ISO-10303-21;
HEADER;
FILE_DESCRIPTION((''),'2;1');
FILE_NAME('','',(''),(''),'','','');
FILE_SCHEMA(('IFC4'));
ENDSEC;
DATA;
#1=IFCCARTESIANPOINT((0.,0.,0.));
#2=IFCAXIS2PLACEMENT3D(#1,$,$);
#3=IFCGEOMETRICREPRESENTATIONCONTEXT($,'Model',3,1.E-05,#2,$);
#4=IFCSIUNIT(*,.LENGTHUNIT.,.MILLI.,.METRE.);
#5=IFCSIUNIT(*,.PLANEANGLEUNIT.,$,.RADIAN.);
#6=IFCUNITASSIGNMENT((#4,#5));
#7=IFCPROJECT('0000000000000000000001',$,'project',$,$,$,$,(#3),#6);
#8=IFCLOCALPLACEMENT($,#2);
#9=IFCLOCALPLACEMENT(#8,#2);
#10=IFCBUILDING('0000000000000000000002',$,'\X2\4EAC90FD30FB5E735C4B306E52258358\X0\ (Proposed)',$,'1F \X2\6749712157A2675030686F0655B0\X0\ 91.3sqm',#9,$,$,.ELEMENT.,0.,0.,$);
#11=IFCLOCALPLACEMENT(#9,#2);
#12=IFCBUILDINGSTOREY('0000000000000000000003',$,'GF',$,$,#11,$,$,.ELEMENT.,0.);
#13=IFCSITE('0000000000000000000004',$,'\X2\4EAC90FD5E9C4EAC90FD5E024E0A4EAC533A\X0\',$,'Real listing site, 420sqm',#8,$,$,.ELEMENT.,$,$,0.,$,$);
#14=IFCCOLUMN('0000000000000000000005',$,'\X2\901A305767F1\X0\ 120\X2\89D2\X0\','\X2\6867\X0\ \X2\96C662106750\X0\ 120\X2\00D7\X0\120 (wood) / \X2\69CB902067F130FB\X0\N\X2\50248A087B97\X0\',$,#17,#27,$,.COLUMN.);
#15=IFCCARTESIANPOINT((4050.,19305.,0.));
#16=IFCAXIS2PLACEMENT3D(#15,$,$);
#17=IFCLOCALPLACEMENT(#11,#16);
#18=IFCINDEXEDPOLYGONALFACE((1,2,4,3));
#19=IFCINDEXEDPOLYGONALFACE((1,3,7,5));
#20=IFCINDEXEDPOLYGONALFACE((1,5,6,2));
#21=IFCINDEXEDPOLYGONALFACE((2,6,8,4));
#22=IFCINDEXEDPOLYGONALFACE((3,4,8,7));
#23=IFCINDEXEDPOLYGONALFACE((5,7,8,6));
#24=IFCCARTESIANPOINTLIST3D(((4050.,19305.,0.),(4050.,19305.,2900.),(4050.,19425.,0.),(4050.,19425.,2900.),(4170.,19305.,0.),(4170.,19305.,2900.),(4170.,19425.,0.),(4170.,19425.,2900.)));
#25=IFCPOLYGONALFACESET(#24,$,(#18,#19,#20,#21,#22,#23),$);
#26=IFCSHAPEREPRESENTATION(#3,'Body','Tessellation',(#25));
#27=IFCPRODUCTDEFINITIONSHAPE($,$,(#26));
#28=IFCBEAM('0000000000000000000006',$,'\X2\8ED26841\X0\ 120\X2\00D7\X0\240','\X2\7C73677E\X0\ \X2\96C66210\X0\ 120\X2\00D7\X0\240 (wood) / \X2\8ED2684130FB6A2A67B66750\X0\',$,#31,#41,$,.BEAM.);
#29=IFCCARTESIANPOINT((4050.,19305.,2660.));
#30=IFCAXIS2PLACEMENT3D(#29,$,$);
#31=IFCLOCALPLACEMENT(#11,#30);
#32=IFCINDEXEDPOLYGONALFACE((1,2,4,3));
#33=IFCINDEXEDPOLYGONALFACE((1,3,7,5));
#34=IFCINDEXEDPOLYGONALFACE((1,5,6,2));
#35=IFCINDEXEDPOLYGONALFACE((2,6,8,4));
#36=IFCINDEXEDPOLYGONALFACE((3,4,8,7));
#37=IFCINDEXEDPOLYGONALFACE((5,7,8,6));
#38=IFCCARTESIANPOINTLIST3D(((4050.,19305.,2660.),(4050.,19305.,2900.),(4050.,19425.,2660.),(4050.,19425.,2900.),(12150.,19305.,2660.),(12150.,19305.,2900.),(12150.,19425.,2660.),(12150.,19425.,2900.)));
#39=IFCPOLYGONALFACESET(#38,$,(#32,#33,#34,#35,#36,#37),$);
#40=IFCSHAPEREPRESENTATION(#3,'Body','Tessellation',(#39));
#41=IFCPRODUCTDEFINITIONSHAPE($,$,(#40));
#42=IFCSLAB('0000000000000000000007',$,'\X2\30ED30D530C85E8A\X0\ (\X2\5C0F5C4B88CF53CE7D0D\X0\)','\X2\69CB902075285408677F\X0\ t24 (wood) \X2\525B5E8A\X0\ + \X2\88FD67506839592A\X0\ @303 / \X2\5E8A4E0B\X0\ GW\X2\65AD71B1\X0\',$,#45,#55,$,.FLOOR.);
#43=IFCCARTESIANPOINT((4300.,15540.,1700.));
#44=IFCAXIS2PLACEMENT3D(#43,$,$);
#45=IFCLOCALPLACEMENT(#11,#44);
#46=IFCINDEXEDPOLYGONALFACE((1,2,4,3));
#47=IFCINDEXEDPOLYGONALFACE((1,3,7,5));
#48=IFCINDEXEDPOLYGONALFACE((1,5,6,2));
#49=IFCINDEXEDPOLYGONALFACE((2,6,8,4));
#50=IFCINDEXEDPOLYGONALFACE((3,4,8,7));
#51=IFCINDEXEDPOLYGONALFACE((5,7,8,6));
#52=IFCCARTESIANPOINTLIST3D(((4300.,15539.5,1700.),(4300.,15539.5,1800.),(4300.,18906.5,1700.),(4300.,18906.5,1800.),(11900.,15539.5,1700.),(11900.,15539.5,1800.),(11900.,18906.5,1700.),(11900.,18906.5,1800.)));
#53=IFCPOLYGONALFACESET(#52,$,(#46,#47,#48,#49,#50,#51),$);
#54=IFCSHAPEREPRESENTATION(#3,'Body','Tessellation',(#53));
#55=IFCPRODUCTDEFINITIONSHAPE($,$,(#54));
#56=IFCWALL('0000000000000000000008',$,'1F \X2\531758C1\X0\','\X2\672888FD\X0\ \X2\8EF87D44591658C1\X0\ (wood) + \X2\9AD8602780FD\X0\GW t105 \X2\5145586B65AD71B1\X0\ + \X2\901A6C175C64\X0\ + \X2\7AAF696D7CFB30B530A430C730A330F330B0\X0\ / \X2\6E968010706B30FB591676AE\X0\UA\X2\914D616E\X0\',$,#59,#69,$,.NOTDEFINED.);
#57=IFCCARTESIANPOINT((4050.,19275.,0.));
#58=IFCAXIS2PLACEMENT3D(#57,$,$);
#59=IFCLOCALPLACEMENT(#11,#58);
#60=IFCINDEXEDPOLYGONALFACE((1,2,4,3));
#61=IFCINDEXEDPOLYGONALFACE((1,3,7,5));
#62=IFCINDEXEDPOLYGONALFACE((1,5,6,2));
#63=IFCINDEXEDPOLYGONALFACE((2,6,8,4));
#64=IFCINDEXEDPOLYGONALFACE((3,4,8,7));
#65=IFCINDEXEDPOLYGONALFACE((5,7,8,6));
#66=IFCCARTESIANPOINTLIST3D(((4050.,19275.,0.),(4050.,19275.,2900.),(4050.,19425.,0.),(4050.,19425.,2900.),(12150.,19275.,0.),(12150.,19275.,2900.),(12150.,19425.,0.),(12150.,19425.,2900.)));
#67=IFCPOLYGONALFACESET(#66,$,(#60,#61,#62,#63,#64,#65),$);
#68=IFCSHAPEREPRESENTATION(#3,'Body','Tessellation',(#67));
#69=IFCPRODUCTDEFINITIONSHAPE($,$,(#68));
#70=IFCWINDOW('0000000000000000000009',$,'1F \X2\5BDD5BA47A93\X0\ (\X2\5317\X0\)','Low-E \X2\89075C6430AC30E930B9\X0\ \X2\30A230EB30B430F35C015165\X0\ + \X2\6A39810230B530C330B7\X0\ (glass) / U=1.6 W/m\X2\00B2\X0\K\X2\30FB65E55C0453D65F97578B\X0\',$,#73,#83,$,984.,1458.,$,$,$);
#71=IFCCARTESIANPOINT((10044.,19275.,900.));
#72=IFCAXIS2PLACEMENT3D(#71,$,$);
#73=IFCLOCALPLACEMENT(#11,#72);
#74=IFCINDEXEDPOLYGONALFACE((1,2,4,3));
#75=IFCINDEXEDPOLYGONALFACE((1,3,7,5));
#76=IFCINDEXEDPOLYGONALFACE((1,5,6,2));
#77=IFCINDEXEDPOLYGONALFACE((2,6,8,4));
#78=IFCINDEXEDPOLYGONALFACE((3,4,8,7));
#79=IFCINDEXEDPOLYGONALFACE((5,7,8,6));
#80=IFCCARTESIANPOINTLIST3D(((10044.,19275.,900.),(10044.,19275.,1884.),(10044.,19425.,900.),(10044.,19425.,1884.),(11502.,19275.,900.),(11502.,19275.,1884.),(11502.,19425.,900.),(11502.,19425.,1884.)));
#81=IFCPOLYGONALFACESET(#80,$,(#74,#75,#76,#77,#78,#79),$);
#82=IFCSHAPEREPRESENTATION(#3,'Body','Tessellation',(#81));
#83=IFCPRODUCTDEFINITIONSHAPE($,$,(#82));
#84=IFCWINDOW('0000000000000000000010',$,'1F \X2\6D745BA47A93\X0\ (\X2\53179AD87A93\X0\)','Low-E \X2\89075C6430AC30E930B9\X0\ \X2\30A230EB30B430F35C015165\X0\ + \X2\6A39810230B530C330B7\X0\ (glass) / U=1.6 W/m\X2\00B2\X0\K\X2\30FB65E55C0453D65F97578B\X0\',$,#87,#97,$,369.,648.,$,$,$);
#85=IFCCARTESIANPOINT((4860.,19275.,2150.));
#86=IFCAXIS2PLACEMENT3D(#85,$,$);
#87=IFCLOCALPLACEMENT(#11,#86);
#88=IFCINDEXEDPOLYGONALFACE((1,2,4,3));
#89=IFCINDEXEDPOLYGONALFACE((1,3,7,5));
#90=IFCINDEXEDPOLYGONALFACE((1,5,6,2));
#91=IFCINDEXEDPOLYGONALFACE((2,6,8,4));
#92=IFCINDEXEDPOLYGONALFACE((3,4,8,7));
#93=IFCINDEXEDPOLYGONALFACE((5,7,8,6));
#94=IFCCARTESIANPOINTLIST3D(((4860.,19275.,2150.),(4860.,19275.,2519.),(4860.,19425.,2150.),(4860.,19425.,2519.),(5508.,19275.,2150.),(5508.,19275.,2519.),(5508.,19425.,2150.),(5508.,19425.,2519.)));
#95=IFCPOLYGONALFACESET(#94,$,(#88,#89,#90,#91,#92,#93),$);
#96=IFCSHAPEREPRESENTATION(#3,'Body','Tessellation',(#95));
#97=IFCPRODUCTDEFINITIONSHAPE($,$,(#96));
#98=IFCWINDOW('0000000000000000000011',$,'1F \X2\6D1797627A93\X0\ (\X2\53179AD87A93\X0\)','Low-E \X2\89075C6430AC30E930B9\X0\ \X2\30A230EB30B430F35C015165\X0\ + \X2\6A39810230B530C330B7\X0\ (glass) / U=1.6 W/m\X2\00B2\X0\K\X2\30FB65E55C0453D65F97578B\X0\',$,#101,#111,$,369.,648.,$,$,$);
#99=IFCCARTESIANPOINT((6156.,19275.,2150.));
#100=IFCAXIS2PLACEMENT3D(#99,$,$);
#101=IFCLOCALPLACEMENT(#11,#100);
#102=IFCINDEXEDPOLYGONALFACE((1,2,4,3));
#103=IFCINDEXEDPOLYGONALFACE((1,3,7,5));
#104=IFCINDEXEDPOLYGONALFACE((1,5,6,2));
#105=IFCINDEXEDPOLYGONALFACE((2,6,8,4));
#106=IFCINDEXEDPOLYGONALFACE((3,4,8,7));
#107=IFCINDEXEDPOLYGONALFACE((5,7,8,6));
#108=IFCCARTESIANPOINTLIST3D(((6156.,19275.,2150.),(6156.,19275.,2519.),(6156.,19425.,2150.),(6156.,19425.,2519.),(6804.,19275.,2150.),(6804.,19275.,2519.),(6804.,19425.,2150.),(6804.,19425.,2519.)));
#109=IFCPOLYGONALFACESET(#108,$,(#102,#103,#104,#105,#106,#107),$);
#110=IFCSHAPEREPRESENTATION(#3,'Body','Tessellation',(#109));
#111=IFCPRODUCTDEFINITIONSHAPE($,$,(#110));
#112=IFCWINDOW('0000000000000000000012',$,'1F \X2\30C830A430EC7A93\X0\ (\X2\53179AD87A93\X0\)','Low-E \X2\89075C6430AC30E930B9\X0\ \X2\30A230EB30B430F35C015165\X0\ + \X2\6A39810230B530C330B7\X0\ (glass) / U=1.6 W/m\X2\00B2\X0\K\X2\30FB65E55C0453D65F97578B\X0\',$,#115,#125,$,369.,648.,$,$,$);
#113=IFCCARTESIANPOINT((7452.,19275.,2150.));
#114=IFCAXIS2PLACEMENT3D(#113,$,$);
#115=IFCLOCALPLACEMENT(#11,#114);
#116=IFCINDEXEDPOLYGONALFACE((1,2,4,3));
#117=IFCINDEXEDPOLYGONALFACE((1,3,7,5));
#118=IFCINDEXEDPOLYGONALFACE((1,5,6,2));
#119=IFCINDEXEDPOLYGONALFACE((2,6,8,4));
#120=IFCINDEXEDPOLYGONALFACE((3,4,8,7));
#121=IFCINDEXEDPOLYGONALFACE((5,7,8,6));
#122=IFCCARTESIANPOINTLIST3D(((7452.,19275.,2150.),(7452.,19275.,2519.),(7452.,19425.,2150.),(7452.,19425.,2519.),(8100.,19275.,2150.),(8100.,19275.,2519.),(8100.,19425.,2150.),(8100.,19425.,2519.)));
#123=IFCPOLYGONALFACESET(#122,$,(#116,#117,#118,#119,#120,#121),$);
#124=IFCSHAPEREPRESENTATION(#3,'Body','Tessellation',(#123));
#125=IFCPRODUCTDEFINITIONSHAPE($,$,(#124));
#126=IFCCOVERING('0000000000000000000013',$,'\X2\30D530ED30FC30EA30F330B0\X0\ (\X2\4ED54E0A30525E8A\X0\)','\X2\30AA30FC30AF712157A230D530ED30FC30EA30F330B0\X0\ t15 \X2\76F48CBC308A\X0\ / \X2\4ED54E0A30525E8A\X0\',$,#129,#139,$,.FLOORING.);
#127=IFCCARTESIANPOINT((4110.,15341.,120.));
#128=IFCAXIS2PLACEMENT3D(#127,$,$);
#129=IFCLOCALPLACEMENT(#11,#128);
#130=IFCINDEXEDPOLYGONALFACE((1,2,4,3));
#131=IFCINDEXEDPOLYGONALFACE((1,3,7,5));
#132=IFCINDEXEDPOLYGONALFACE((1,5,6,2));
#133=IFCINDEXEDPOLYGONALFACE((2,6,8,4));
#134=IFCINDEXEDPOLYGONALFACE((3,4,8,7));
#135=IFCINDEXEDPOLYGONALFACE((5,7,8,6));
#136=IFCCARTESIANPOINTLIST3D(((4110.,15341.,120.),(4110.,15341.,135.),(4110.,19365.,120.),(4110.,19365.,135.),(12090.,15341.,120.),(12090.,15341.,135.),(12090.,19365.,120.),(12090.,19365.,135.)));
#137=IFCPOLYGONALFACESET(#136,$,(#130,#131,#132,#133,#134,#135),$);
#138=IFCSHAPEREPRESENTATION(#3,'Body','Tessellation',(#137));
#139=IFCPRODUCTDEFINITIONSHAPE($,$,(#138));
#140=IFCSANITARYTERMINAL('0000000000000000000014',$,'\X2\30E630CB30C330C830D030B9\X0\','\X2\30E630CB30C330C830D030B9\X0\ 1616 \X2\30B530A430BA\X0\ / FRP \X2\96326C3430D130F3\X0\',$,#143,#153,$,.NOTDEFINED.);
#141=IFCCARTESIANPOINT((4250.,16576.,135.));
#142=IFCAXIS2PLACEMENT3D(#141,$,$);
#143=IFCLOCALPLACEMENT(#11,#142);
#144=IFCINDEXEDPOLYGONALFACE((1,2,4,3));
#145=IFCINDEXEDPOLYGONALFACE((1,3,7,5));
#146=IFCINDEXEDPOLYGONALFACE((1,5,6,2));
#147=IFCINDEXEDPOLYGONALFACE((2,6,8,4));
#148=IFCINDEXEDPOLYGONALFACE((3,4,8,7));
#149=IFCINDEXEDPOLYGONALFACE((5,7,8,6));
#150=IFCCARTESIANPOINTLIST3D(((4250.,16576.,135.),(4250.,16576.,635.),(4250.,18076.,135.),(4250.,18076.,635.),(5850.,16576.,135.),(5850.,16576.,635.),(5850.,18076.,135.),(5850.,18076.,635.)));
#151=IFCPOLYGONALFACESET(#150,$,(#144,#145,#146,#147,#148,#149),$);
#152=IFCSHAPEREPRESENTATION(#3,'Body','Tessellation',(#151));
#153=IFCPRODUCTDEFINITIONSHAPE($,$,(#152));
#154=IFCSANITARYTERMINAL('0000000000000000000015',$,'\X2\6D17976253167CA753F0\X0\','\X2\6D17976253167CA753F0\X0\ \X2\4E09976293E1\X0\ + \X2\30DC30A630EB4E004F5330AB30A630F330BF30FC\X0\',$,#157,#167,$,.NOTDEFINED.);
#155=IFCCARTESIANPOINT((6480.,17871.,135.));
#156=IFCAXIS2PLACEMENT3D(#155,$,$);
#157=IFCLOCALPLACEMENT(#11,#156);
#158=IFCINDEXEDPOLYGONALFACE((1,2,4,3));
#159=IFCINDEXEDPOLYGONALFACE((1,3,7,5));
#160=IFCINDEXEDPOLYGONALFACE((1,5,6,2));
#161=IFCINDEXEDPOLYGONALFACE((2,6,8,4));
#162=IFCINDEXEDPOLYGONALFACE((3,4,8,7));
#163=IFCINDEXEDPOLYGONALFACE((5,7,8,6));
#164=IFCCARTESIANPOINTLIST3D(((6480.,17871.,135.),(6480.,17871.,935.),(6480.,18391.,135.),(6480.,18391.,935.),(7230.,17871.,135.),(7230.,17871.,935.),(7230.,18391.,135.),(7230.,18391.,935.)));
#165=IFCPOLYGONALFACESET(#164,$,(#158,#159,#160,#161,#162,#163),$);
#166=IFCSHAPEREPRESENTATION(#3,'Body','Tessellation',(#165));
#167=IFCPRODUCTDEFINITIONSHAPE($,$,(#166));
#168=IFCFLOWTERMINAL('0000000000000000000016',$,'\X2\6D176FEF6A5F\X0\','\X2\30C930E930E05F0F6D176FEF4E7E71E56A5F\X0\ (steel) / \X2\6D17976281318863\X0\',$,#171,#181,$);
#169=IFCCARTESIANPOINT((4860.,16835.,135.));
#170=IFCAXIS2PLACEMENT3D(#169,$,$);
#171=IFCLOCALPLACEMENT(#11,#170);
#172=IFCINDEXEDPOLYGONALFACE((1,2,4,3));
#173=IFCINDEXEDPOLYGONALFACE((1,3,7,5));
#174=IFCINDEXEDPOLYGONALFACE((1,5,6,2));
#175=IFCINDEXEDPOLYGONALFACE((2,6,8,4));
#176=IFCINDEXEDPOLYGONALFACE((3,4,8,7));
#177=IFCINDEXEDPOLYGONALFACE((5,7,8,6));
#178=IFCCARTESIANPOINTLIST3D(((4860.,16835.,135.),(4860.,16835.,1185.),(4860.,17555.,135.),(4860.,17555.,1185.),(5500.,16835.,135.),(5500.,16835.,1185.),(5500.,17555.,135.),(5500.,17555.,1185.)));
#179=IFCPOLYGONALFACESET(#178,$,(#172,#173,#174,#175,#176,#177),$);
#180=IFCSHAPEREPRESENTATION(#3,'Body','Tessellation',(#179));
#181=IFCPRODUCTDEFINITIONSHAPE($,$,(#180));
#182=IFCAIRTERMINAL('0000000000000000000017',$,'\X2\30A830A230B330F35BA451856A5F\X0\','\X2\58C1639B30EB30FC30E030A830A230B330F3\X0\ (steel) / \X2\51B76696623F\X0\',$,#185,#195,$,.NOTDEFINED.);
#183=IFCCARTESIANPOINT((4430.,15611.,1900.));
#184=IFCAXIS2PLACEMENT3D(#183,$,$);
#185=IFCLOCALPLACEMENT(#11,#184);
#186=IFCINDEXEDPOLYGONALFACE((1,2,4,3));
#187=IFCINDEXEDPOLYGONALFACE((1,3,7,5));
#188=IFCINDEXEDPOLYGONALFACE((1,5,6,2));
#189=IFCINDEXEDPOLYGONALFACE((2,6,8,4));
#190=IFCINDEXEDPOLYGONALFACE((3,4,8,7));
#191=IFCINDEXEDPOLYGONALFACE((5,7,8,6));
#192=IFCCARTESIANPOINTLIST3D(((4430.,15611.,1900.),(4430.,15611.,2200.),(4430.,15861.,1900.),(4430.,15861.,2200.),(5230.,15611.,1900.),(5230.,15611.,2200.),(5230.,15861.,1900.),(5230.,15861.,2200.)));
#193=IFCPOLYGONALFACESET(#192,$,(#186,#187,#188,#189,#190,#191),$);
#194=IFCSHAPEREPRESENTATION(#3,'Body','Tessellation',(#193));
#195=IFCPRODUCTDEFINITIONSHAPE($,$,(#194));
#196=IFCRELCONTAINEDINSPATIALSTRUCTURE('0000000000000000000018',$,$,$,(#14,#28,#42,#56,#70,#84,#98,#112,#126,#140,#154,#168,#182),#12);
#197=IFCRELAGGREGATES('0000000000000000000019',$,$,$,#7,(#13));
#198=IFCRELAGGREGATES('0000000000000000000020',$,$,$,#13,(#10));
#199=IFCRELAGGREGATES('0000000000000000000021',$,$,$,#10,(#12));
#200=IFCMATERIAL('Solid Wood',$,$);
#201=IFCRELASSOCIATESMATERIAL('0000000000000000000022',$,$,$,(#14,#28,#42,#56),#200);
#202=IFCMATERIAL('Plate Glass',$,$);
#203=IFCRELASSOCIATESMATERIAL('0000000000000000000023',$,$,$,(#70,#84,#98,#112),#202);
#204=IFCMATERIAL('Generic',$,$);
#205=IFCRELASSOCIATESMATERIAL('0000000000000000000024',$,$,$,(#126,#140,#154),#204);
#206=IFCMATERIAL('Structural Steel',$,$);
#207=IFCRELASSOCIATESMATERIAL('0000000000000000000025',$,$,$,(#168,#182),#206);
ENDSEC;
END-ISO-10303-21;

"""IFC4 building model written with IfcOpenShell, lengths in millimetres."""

from ifc_helpers import new_model, si_unit, frame, frame_2d, origin, place, context, project, spatial, rectangle, extrude, material, element, fill, save


model = new_model("IFC4")

# Units and contexts
model_context = context("Model", 3, precision=1e-05, world=origin())
ifc_project = project(units=[si_unit("LENGTHUNIT", "METRE", prefix="MILLI"), si_unit("PLANEANGLEUNIT", "RADIAN")], contexts=[model_context])

# Site, building, storey
site_placement = place(None, origin())
site = spatial("IfcSite", under=ifc_project, at=site_placement, Name="京都府京都市上京区", ObjectType="Real listing site, 420sqm", CompositionType="ELEMENT", RefElevation=0.0)
building_placement = place(site_placement, origin())
building = spatial("IfcBuilding", under=site, at=building_placement, Name="京都・平屋の別荘 (Proposed)", ObjectType="1F 杉無垢材と漆喰 91.3sqm", CompositionType="ELEMENT", ElevationOfRefHeight=0.0, ElevationOfTerrain=0.0)
storey_placement = place(building_placement, origin())
storey = spatial("IfcBuildingStorey", under=building, at=storey_placement, Name="GF", CompositionType="ELEMENT", Elevation=0.0)

# Column
ifc_material_1 = material(Name="Solid Wood")
column_1_placement = place(storey_placement, frame((4050.0, 19305.0, 0.0)))
element("IfcColumn", 1, at=column_1_placement, inside=storey, material=ifc_material_1, Name="通し柱 120角", Description="桧 集成材 120×120 (wood) / 構造柱・N値計算", PredefinedType="COLUMN", context=model_context, shape_type="SweptSolid", body=[
    extrude(rectangle(XDim=120.0, YDim=120.0, at=frame_2d((60.0, 60.0))), frame((4050.0, 19305.0, 0.0)), (0.0, 0.0, 1.0), 2900.0),
])

# Beam
beam_1_placement = place(storey_placement, frame((4050.0, 19305.0, 2660.0)))
element("IfcBeam", 2, at=beam_1_placement, inside=storey, material=ifc_material_1, Name="軒桁 120×240", Description="米松 集成 120×240 (wood) / 軒桁・横架材", PredefinedType="BEAM", context=model_context, shape_type="SweptSolid", body=[
    extrude(rectangle(XDim=8100.0, YDim=120.0, at=frame_2d((4050.0, 60.0))), frame((4050.0, 19305.0, 2660.0)), (0.0, 0.0, 1.0), 240.0),
])

# Slab
slab_placement = place(storey_placement, frame((4300.0, 15540.0, 1700.0)))
element("IfcSlab", 3, at=slab_placement, inside=storey, material=ifc_material_1, Name="ロフト床 (小屋裏収納)", Description="構造用合板 t24 (wood) 剛床 + 製材根太 @303 / 床下 GW断熱", PredefinedType="FLOOR", context=model_context, shape_type="SweptSolid", body=[
    extrude(rectangle(XDim=7600.0, YDim=3367.0, at=frame_2d((3800.0, 1683.0))), frame((4300.0, 15540.0, 1700.0)), (0.0, 0.0, 1.0), 100.0),
])

# Wall, openings, windows
wall_1_placement = place(storey_placement, frame((4050.0, 19275.0, 0.0)))
wall_1 = element("IfcWall", 4, at=wall_1_placement, inside=storey, material=ifc_material_1, Name="1F 北壁", Description="木製 軸組外壁 (wood) + 高性能GW t105 充填断熱 + 通気層 + 窯業系サイディング / 準耐火・外皮UA配慮", PredefinedType="NOTDEFINED", context=model_context, shape_type="SweptSolid", body=[
    extrude(rectangle(XDim=8100.0, YDim=150.0, at=frame_2d((4050.0, 75.0))), frame((4050.0, 19275.0, 0.0)), (0.0, 0.0, 1.0), 2900.0),
])
opening_1_placement = place(storey_placement, frame((10044.0, 19275.0, 900.0)))
opening_1 = element("IfcOpeningElement", 5, at=opening_1_placement, cuts=wall_1, PredefinedType="NOTDEFINED", context=model_context, shape_type="SweptSolid", body=[
    extrude(rectangle(XDim=1458.0, YDim=150.0, at=frame_2d((729.0, 75.0))), frame((10044.0, 19275.0, 900.0)), (0.0, 0.0, 1.0), 984.0),
])
opening_2_placement = place(storey_placement, frame((4860.0, 19275.0, 2150.0)))
opening_2 = element("IfcOpeningElement", 6, at=opening_2_placement, cuts=wall_1, PredefinedType="NOTDEFINED", context=model_context, shape_type="SweptSolid", body=[
    extrude(rectangle(XDim=648.0, YDim=150.0, at=frame_2d((324.0, 75.0))), frame((4860.0, 19275.0, 2150.0)), (0.0, 0.0, 1.0), 369.0),
])
opening_3_placement = place(storey_placement, frame((6156.0, 19275.0, 2150.0)))
opening_3 = element("IfcOpeningElement", 7, at=opening_3_placement, cuts=wall_1, PredefinedType="NOTDEFINED", context=model_context, shape_type="SweptSolid", body=[
    extrude(rectangle(XDim=648.0, YDim=150.0, at=frame_2d((324.0, 75.0))), frame((6156.0, 19275.0, 2150.0)), (0.0, 0.0, 1.0), 369.0),
])
opening_4_placement = place(storey_placement, frame((7452.0, 19275.0, 2150.0)))
opening_4 = element("IfcOpeningElement", 8, at=opening_4_placement, cuts=wall_1, PredefinedType="NOTDEFINED", context=model_context, shape_type="SweptSolid", body=[
    extrude(rectangle(XDim=648.0, YDim=150.0, at=frame_2d((324.0, 75.0))), frame((7452.0, 19275.0, 2150.0)), (0.0, 0.0, 1.0), 369.0),
])
ifc_material_2 = material(Name="Plate Glass")
window_1_placement = place(storey_placement, frame((10044.0, 19275.0, 900.0)))
window_1 = element("IfcWindow", 9, at=window_1_placement, inside=storey, material=ifc_material_2, Name="1F 寝室窓 (北)", Description="Low-E 複層ガラス アルゴン封入 + 樹脂サッシ (glass) / U=1.6 W/m²K・日射取得型", OverallHeight=984.0, OverallWidth=1458.0, context=model_context, shape_type="SweptSolid", body=[
    extrude(rectangle(XDim=1458.0, YDim=150.0, at=frame_2d((729.0, 75.0))), frame((10044.0, 19275.0, 900.0)), (0.0, 0.0, 1.0), 984.0),
])
fill(opening_1, window_1)
window_2_placement = place(storey_placement, frame((4860.0, 19275.0, 2150.0)))
window_2 = element("IfcWindow", 10, at=window_2_placement, inside=storey, material=ifc_material_2, Name="1F 浴室窓 (北高窓)", Description="Low-E 複層ガラス アルゴン封入 + 樹脂サッシ (glass) / U=1.6 W/m²K・日射取得型", OverallHeight=369.0, OverallWidth=648.0, context=model_context, shape_type="SweptSolid", body=[
    extrude(rectangle(XDim=648.0, YDim=150.0, at=frame_2d((324.0, 75.0))), frame((4860.0, 19275.0, 2150.0)), (0.0, 0.0, 1.0), 369.0),
])
fill(opening_2, window_2)
window_3_placement = place(storey_placement, frame((6156.0, 19275.0, 2150.0)))
window_3 = element("IfcWindow", 11, at=window_3_placement, inside=storey, material=ifc_material_2, Name="1F 洗面窓 (北高窓)", Description="Low-E 複層ガラス アルゴン封入 + 樹脂サッシ (glass) / U=1.6 W/m²K・日射取得型", OverallHeight=369.0, OverallWidth=648.0, context=model_context, shape_type="SweptSolid", body=[
    extrude(rectangle(XDim=648.0, YDim=150.0, at=frame_2d((324.0, 75.0))), frame((6156.0, 19275.0, 2150.0)), (0.0, 0.0, 1.0), 369.0),
])
fill(opening_3, window_3)
window_4_placement = place(storey_placement, frame((7452.0, 19275.0, 2150.0)))
window_4 = element("IfcWindow", 12, at=window_4_placement, inside=storey, material=ifc_material_2, Name="1F トイレ窓 (北高窓)", Description="Low-E 複層ガラス アルゴン封入 + 樹脂サッシ (glass) / U=1.6 W/m²K・日射取得型", OverallHeight=369.0, OverallWidth=648.0, context=model_context, shape_type="SweptSolid", body=[
    extrude(rectangle(XDim=648.0, YDim=150.0, at=frame_2d((324.0, 75.0))), frame((7452.0, 19275.0, 2150.0)), (0.0, 0.0, 1.0), 369.0),
])
fill(opening_4, window_4)

# Covering
ifc_material_3 = material(Name="Generic")
covering_placement = place(storey_placement, frame((4110.0, 15341.0, 120.0)))
element("IfcCovering", 13, at=covering_placement, inside=storey, material=ifc_material_3, Name="フローリング (仕上げ床)", Description="オーク無垢フローリング t15 直貼り / 仕上げ床", PredefinedType="FLOORING", context=model_context, shape_type="SweptSolid", body=[
    extrude(rectangle(XDim=7980.0, YDim=4024.0, at=frame_2d((3990.0, 2012.0))), frame((4110.0, 15341.0, 120.0)), (0.0, 0.0, 1.0), 15.0),
])

# Sanitary terminals
sanitary_terminal_1_placement = place(storey_placement, frame((4250.0, 16576.0, 135.0)))
element("IfcSanitaryTerminal", 14, at=sanitary_terminal_1_placement, inside=storey, material=ifc_material_3, Name="ユニットバス", Description="ユニットバス 1616 サイズ / FRP 防水パン", PredefinedType="NOTDEFINED", context=model_context, shape_type="SweptSolid", body=[
    extrude(rectangle(XDim=1600.0, YDim=1500.0, at=frame_2d((800.0, 750.0))), frame((4250.0, 16576.0, 135.0)), (0.0, 0.0, 1.0), 500.0),
])
sanitary_terminal_2_placement = place(storey_placement, frame((6480.0, 17871.0, 135.0)))
element("IfcSanitaryTerminal", 15, at=sanitary_terminal_2_placement, inside=storey, material=ifc_material_3, Name="洗面化粧台", Description="洗面化粧台 三面鏡 + ボウル一体カウンター", PredefinedType="NOTDEFINED", context=model_context, shape_type="SweptSolid", body=[
    extrude(rectangle(XDim=750.0, YDim=520.0, at=frame_2d((375.0, 260.0))), frame((6480.0, 17871.0, 135.0)), (0.0, 0.0, 1.0), 800.0),
])

# Flow terminal
ifc_material_4 = material(Name="Structural Steel")
flow_terminal_placement = place(storey_placement, frame((4860.0, 16835.0, 135.0)))
element("IfcFlowTerminal", 16, at=flow_terminal_placement, inside=storey, material=ifc_material_4, Name="洗濯機", Description="ドラム式洗濯乾燥機 (steel) / 洗面脱衣", context=model_context, shape_type="SweptSolid", body=[
    extrude(rectangle(XDim=640.0, YDim=720.0, at=frame_2d((320.0, 360.0))), frame((4860.0, 16835.0, 135.0)), (0.0, 0.0, 1.0), 1050.0),
])

# Air terminal
air_terminal_placement = place(storey_placement, frame((4430.0, 15611.0, 1900.0)))
element("IfcAirTerminal", 17, at=air_terminal_placement, inside=storey, material=ifc_material_4, Name="エアコン室内機", Description="壁掛ルームエアコン (steel) / 冷暖房", PredefinedType="NOTDEFINED", context=model_context, shape_type="SweptSolid", body=[
    extrude(rectangle(XDim=800.0, YDim=250.0, at=frame_2d((400.0, 125.0))), frame((4430.0, 15611.0, 1900.0)), (0.0, 0.0, 1.0), 300.0),
])

save(model, "model.ifc")
